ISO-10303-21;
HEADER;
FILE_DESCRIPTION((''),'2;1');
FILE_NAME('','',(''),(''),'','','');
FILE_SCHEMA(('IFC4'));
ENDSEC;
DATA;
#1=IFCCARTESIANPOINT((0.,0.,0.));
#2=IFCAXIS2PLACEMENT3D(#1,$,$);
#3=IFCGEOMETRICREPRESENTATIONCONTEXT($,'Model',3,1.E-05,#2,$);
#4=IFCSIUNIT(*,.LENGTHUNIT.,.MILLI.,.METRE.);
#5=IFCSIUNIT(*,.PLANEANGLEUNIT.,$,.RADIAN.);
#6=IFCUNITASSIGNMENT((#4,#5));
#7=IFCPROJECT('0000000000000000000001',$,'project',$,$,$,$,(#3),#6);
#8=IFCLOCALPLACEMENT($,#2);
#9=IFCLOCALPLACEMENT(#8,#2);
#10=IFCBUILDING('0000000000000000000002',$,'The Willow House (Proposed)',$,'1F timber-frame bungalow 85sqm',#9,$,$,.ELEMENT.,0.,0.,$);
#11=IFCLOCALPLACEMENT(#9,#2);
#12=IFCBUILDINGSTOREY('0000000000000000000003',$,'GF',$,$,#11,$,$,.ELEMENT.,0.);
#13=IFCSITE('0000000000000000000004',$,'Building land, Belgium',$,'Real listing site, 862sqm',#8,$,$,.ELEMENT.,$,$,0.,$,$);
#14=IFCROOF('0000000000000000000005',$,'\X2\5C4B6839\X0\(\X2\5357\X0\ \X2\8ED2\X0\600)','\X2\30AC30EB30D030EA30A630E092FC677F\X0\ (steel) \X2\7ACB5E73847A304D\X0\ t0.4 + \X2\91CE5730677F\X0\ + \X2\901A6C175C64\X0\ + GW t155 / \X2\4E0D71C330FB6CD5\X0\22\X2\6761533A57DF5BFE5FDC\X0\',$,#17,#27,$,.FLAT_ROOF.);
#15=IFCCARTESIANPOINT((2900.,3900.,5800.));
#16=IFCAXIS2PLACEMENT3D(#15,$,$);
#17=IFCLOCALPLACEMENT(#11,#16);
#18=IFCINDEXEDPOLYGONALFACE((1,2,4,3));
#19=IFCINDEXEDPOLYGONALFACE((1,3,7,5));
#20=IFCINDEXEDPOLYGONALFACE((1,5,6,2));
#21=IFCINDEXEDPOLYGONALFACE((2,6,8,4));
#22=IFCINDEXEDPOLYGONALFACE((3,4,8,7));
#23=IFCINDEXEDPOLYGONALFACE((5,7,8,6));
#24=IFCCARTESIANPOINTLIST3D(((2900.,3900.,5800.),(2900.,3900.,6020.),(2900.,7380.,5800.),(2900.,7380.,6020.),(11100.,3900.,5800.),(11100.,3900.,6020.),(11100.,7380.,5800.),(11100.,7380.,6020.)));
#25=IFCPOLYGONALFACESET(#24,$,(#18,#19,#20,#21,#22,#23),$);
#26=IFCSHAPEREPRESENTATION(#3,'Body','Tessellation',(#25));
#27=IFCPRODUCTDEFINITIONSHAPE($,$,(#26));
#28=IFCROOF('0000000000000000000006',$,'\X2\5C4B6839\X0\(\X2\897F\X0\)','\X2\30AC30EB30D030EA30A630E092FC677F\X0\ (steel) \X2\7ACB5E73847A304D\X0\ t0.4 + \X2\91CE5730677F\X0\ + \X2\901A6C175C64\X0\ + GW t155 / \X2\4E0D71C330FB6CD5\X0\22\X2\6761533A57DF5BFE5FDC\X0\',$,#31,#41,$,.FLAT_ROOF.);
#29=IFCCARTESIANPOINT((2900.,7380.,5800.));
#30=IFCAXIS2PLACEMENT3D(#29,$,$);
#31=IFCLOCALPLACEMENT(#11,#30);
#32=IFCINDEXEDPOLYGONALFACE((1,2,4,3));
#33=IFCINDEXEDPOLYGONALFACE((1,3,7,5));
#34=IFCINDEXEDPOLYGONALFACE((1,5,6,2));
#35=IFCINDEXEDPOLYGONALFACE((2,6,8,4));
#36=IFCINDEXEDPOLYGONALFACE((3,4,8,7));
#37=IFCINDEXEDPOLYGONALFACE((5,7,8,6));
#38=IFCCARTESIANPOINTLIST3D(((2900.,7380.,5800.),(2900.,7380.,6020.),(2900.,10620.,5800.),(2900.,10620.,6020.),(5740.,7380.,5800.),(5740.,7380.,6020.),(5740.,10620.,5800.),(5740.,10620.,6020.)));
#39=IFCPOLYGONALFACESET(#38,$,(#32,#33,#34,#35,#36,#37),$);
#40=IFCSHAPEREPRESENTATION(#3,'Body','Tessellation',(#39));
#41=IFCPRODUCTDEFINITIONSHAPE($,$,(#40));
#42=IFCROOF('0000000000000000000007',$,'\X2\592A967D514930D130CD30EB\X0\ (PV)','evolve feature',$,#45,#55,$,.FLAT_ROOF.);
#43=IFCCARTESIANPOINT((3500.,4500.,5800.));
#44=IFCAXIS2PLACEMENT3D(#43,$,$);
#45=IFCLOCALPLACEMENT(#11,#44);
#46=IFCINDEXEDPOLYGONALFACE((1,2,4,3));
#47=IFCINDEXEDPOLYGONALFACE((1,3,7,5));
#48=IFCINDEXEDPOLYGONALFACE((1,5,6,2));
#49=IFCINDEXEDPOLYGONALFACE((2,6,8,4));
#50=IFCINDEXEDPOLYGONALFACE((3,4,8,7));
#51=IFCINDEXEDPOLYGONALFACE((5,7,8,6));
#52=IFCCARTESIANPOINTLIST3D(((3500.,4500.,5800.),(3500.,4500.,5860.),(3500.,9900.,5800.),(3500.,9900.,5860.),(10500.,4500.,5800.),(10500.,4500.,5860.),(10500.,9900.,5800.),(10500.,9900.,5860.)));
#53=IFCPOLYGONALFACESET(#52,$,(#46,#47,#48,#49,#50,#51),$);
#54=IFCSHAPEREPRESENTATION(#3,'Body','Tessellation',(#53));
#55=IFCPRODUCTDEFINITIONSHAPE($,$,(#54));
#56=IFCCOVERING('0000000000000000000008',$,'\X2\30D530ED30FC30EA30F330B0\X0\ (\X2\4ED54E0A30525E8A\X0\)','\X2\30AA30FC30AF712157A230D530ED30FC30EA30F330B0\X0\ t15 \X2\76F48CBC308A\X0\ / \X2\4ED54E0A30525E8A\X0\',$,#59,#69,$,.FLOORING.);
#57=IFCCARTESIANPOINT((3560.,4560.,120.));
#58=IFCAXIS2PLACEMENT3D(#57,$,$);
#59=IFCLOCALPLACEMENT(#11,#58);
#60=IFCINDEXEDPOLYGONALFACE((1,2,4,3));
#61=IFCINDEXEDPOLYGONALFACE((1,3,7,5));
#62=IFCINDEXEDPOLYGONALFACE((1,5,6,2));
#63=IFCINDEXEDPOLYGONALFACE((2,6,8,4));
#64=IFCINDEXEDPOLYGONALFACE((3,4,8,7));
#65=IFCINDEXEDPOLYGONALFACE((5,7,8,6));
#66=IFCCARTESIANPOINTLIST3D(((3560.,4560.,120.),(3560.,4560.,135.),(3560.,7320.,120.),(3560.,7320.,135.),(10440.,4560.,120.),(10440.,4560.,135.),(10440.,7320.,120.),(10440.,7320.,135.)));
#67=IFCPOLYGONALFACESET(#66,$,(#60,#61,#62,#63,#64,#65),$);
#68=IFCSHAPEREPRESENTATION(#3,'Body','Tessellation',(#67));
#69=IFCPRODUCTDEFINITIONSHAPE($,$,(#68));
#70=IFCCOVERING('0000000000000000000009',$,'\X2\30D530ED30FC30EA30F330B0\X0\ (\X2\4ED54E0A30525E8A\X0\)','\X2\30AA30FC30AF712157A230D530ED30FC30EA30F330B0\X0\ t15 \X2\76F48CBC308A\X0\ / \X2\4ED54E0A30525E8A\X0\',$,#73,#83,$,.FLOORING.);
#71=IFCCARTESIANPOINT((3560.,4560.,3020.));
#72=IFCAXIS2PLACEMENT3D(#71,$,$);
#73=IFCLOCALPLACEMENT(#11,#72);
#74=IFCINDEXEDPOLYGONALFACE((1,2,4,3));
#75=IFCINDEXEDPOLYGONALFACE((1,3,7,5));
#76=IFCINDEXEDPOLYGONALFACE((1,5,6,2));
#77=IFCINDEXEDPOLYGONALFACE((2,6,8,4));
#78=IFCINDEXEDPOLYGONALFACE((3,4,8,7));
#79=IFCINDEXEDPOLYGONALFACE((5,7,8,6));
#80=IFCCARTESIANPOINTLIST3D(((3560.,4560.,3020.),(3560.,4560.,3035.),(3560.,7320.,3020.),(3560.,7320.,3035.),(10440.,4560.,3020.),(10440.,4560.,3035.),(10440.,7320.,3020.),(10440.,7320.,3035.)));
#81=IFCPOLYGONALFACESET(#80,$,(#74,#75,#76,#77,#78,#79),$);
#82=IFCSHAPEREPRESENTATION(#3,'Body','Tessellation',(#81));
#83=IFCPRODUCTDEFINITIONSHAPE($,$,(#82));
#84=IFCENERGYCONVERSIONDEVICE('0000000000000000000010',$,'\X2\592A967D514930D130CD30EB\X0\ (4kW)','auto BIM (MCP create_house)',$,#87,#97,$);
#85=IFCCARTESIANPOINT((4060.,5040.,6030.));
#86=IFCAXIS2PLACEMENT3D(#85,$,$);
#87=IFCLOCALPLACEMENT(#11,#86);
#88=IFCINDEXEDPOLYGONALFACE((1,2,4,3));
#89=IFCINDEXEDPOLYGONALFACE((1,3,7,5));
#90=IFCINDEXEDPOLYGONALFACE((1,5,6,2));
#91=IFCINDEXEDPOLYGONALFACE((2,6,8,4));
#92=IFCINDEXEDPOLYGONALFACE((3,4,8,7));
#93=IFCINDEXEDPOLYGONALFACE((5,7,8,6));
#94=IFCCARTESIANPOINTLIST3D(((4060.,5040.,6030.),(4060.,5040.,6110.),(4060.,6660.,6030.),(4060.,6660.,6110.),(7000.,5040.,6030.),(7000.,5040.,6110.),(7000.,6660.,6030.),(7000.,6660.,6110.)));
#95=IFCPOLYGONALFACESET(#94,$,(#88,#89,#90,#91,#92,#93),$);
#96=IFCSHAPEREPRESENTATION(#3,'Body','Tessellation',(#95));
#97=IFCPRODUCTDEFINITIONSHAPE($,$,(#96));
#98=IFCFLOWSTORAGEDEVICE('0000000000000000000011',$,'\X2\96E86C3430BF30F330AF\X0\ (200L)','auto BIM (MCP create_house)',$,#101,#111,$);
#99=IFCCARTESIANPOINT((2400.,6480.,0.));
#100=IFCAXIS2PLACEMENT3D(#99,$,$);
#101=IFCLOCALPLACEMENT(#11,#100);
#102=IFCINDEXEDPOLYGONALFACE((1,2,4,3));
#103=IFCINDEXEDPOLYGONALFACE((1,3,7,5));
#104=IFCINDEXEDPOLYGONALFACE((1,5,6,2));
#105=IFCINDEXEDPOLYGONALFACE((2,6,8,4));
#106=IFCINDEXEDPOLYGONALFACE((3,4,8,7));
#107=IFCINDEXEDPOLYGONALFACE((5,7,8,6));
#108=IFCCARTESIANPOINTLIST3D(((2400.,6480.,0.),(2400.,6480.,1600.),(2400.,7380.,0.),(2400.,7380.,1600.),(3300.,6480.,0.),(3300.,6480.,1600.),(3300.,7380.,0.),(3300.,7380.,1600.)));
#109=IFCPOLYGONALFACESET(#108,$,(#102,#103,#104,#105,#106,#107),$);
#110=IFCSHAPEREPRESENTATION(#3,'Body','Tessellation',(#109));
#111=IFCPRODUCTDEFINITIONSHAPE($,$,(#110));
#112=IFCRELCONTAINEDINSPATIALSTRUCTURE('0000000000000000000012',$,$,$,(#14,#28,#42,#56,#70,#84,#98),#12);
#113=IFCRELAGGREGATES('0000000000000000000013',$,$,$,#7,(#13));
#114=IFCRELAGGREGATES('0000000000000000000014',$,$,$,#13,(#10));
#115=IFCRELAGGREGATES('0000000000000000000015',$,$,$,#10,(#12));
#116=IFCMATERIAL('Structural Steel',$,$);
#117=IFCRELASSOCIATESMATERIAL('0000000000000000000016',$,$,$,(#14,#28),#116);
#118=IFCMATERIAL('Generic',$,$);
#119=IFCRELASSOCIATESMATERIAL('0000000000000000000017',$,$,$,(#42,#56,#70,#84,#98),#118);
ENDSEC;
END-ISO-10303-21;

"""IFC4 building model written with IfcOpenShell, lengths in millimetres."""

from ifc_helpers import new_model, si_unit, frame, frame_2d, origin, place, context, project, spatial, rectangle, extrude, material, element, save


model = new_model("IFC4")

# Units and contexts
model_context = context("Model", 3, precision=1e-05, world=origin())
ifc_project = project(units=[si_unit("LENGTHUNIT", "METRE", prefix="MILLI"), si_unit("PLANEANGLEUNIT", "RADIAN")], contexts=[model_context])

# Site, building, storey
site_placement = place(None, origin())
site = spatial("IfcSite", under=ifc_project, at=site_placement, Name="Building land, Belgium", ObjectType="Real listing site, 862sqm", CompositionType="ELEMENT", RefElevation=0.0)
building_placement = place(site_placement, origin())
building = spatial("IfcBuilding", under=site, at=building_placement, Name="The Willow House (Proposed)", ObjectType="1F timber-frame bungalow 85sqm", CompositionType="ELEMENT", ElevationOfRefHeight=0.0, ElevationOfTerrain=0.0)
storey_placement = place(building_placement, origin())
storey = spatial("IfcBuildingStorey", under=building, at=storey_placement, Name="GF", CompositionType="ELEMENT", Elevation=0.0)

# Shared definitions
ifc_material_1 = material(Name="Generic")

# Roofs
ifc_material_2 = material(Name="Structural Steel")
roof_1_placement = place(storey_placement, frame((2900.0, 3900.0, 5800.0)))
element("IfcRoof", 1, at=roof_1_placement, inside=storey, material=ifc_material_2, Name="屋根(南 軒600)", Description="ガルバリウム鋼板 (steel) 立平葺き t0.4 + 野地板 + 通気層 + GW t155 / 不燃・法22条区域対応", PredefinedType="FLAT_ROOF", context=model_context, shape_type="SweptSolid", body=[
    extrude(rectangle(XDim=8200.0, YDim=3480.0, at=frame_2d((4100.0, 1740.0))), frame((2900.0, 3900.0, 5800.0)), (0.0, 0.0, 1.0), 220.0),
])
roof_2_placement = place(storey_placement, frame((2900.0, 7380.0, 5800.0)))
element("IfcRoof", 2, at=roof_2_placement, inside=storey, material=ifc_material_2, Name="屋根(西)", Description="ガルバリウム鋼板 (steel) 立平葺き t0.4 + 野地板 + 通気層 + GW t155 / 不燃・法22条区域対応", PredefinedType="FLAT_ROOF", context=model_context, shape_type="SweptSolid", body=[
    extrude(rectangle(XDim=2840.0, YDim=3240.0, at=frame_2d((1420.0, 1620.0))), frame((2900.0, 7380.0, 5800.0)), (0.0, 0.0, 1.0), 220.0),
])
roof_3_placement = place(storey_placement, frame((3500.0, 4500.0, 5800.0)))
element("IfcRoof", 3, at=roof_3_placement, inside=storey, material=ifc_material_1, Name="太陽光パネル (PV)", Description="evolve feature", PredefinedType="FLAT_ROOF", context=model_context, shape_type="SweptSolid", body=[
    extrude(rectangle(XDim=7000.0, YDim=5400.0, at=frame_2d((3500.0, 2700.0))), frame((3500.0, 4500.0, 5800.0)), (0.0, 0.0, 1.0), 60.0),
])

# Coverings
covering_1_placement = place(storey_placement, frame((3560.0, 4560.0, 120.0)))
element("IfcCovering", 4, at=covering_1_placement, inside=storey, material=ifc_material_1, Name="フローリング (仕上げ床)", Description="オーク無垢フローリング t15 直貼り / 仕上げ床", PredefinedType="FLOORING", context=model_context, shape_type="SweptSolid", body=[
    extrude(rectangle(XDim=6880.0, YDim=2760.0, at=frame_2d((3440.0, 1380.0))), frame((3560.0, 4560.0, 120.0)), (0.0, 0.0, 1.0), 15.0),
])
covering_2_placement = place(storey_placement, frame((3560.0, 4560.0, 3020.0)))
element("IfcCovering", 5, at=covering_2_placement, inside=storey, material=ifc_material_1, Name="フローリング (仕上げ床)", Description="オーク無垢フローリング t15 直貼り / 仕上げ床", PredefinedType="FLOORING", context=model_context, shape_type="SweptSolid", body=[
    extrude(rectangle(XDim=6880.0, YDim=2760.0, at=frame_2d((3440.0, 1380.0))), frame((3560.0, 4560.0, 3020.0)), (0.0, 0.0, 1.0), 15.0),
])

# Energy conversion device
energy_conversion_device_placement = place(storey_placement, frame((4060.0, 5040.0, 6030.0)))
element("IfcEnergyConversionDevice", 6, at=energy_conversion_device_placement, inside=storey, material=ifc_material_1, Name="太陽光パネル (4kW)", Description="auto BIM (MCP create_house)", context=model_context, shape_type="SweptSolid", body=[
    extrude(rectangle(XDim=2940.0, YDim=1620.0, at=frame_2d((1470.0, 810.0))), frame((4060.0, 5040.0, 6030.0)), (0.0, 0.0, 1.0), 80.0),
])

# Flow storage device
flow_storage_device_placement = place(storey_placement, frame((2400.0, 6480.0, 0.0)))
element("IfcFlowStorageDevice", 7, at=flow_storage_device_placement, inside=storey, material=ifc_material_1, Name="雨水タンク (200L)", Description="auto BIM (MCP create_house)", context=model_context, shape_type="SweptSolid", body=[
    extrude(rectangle(XDim=900.0, YDim=900.0, at=frame_2d((450.0, 450.0))), frame((2400.0, 6480.0, 0.0)), (0.0, 0.0, 1.0), 1600.0),
])

save(model, "model.ifc")
